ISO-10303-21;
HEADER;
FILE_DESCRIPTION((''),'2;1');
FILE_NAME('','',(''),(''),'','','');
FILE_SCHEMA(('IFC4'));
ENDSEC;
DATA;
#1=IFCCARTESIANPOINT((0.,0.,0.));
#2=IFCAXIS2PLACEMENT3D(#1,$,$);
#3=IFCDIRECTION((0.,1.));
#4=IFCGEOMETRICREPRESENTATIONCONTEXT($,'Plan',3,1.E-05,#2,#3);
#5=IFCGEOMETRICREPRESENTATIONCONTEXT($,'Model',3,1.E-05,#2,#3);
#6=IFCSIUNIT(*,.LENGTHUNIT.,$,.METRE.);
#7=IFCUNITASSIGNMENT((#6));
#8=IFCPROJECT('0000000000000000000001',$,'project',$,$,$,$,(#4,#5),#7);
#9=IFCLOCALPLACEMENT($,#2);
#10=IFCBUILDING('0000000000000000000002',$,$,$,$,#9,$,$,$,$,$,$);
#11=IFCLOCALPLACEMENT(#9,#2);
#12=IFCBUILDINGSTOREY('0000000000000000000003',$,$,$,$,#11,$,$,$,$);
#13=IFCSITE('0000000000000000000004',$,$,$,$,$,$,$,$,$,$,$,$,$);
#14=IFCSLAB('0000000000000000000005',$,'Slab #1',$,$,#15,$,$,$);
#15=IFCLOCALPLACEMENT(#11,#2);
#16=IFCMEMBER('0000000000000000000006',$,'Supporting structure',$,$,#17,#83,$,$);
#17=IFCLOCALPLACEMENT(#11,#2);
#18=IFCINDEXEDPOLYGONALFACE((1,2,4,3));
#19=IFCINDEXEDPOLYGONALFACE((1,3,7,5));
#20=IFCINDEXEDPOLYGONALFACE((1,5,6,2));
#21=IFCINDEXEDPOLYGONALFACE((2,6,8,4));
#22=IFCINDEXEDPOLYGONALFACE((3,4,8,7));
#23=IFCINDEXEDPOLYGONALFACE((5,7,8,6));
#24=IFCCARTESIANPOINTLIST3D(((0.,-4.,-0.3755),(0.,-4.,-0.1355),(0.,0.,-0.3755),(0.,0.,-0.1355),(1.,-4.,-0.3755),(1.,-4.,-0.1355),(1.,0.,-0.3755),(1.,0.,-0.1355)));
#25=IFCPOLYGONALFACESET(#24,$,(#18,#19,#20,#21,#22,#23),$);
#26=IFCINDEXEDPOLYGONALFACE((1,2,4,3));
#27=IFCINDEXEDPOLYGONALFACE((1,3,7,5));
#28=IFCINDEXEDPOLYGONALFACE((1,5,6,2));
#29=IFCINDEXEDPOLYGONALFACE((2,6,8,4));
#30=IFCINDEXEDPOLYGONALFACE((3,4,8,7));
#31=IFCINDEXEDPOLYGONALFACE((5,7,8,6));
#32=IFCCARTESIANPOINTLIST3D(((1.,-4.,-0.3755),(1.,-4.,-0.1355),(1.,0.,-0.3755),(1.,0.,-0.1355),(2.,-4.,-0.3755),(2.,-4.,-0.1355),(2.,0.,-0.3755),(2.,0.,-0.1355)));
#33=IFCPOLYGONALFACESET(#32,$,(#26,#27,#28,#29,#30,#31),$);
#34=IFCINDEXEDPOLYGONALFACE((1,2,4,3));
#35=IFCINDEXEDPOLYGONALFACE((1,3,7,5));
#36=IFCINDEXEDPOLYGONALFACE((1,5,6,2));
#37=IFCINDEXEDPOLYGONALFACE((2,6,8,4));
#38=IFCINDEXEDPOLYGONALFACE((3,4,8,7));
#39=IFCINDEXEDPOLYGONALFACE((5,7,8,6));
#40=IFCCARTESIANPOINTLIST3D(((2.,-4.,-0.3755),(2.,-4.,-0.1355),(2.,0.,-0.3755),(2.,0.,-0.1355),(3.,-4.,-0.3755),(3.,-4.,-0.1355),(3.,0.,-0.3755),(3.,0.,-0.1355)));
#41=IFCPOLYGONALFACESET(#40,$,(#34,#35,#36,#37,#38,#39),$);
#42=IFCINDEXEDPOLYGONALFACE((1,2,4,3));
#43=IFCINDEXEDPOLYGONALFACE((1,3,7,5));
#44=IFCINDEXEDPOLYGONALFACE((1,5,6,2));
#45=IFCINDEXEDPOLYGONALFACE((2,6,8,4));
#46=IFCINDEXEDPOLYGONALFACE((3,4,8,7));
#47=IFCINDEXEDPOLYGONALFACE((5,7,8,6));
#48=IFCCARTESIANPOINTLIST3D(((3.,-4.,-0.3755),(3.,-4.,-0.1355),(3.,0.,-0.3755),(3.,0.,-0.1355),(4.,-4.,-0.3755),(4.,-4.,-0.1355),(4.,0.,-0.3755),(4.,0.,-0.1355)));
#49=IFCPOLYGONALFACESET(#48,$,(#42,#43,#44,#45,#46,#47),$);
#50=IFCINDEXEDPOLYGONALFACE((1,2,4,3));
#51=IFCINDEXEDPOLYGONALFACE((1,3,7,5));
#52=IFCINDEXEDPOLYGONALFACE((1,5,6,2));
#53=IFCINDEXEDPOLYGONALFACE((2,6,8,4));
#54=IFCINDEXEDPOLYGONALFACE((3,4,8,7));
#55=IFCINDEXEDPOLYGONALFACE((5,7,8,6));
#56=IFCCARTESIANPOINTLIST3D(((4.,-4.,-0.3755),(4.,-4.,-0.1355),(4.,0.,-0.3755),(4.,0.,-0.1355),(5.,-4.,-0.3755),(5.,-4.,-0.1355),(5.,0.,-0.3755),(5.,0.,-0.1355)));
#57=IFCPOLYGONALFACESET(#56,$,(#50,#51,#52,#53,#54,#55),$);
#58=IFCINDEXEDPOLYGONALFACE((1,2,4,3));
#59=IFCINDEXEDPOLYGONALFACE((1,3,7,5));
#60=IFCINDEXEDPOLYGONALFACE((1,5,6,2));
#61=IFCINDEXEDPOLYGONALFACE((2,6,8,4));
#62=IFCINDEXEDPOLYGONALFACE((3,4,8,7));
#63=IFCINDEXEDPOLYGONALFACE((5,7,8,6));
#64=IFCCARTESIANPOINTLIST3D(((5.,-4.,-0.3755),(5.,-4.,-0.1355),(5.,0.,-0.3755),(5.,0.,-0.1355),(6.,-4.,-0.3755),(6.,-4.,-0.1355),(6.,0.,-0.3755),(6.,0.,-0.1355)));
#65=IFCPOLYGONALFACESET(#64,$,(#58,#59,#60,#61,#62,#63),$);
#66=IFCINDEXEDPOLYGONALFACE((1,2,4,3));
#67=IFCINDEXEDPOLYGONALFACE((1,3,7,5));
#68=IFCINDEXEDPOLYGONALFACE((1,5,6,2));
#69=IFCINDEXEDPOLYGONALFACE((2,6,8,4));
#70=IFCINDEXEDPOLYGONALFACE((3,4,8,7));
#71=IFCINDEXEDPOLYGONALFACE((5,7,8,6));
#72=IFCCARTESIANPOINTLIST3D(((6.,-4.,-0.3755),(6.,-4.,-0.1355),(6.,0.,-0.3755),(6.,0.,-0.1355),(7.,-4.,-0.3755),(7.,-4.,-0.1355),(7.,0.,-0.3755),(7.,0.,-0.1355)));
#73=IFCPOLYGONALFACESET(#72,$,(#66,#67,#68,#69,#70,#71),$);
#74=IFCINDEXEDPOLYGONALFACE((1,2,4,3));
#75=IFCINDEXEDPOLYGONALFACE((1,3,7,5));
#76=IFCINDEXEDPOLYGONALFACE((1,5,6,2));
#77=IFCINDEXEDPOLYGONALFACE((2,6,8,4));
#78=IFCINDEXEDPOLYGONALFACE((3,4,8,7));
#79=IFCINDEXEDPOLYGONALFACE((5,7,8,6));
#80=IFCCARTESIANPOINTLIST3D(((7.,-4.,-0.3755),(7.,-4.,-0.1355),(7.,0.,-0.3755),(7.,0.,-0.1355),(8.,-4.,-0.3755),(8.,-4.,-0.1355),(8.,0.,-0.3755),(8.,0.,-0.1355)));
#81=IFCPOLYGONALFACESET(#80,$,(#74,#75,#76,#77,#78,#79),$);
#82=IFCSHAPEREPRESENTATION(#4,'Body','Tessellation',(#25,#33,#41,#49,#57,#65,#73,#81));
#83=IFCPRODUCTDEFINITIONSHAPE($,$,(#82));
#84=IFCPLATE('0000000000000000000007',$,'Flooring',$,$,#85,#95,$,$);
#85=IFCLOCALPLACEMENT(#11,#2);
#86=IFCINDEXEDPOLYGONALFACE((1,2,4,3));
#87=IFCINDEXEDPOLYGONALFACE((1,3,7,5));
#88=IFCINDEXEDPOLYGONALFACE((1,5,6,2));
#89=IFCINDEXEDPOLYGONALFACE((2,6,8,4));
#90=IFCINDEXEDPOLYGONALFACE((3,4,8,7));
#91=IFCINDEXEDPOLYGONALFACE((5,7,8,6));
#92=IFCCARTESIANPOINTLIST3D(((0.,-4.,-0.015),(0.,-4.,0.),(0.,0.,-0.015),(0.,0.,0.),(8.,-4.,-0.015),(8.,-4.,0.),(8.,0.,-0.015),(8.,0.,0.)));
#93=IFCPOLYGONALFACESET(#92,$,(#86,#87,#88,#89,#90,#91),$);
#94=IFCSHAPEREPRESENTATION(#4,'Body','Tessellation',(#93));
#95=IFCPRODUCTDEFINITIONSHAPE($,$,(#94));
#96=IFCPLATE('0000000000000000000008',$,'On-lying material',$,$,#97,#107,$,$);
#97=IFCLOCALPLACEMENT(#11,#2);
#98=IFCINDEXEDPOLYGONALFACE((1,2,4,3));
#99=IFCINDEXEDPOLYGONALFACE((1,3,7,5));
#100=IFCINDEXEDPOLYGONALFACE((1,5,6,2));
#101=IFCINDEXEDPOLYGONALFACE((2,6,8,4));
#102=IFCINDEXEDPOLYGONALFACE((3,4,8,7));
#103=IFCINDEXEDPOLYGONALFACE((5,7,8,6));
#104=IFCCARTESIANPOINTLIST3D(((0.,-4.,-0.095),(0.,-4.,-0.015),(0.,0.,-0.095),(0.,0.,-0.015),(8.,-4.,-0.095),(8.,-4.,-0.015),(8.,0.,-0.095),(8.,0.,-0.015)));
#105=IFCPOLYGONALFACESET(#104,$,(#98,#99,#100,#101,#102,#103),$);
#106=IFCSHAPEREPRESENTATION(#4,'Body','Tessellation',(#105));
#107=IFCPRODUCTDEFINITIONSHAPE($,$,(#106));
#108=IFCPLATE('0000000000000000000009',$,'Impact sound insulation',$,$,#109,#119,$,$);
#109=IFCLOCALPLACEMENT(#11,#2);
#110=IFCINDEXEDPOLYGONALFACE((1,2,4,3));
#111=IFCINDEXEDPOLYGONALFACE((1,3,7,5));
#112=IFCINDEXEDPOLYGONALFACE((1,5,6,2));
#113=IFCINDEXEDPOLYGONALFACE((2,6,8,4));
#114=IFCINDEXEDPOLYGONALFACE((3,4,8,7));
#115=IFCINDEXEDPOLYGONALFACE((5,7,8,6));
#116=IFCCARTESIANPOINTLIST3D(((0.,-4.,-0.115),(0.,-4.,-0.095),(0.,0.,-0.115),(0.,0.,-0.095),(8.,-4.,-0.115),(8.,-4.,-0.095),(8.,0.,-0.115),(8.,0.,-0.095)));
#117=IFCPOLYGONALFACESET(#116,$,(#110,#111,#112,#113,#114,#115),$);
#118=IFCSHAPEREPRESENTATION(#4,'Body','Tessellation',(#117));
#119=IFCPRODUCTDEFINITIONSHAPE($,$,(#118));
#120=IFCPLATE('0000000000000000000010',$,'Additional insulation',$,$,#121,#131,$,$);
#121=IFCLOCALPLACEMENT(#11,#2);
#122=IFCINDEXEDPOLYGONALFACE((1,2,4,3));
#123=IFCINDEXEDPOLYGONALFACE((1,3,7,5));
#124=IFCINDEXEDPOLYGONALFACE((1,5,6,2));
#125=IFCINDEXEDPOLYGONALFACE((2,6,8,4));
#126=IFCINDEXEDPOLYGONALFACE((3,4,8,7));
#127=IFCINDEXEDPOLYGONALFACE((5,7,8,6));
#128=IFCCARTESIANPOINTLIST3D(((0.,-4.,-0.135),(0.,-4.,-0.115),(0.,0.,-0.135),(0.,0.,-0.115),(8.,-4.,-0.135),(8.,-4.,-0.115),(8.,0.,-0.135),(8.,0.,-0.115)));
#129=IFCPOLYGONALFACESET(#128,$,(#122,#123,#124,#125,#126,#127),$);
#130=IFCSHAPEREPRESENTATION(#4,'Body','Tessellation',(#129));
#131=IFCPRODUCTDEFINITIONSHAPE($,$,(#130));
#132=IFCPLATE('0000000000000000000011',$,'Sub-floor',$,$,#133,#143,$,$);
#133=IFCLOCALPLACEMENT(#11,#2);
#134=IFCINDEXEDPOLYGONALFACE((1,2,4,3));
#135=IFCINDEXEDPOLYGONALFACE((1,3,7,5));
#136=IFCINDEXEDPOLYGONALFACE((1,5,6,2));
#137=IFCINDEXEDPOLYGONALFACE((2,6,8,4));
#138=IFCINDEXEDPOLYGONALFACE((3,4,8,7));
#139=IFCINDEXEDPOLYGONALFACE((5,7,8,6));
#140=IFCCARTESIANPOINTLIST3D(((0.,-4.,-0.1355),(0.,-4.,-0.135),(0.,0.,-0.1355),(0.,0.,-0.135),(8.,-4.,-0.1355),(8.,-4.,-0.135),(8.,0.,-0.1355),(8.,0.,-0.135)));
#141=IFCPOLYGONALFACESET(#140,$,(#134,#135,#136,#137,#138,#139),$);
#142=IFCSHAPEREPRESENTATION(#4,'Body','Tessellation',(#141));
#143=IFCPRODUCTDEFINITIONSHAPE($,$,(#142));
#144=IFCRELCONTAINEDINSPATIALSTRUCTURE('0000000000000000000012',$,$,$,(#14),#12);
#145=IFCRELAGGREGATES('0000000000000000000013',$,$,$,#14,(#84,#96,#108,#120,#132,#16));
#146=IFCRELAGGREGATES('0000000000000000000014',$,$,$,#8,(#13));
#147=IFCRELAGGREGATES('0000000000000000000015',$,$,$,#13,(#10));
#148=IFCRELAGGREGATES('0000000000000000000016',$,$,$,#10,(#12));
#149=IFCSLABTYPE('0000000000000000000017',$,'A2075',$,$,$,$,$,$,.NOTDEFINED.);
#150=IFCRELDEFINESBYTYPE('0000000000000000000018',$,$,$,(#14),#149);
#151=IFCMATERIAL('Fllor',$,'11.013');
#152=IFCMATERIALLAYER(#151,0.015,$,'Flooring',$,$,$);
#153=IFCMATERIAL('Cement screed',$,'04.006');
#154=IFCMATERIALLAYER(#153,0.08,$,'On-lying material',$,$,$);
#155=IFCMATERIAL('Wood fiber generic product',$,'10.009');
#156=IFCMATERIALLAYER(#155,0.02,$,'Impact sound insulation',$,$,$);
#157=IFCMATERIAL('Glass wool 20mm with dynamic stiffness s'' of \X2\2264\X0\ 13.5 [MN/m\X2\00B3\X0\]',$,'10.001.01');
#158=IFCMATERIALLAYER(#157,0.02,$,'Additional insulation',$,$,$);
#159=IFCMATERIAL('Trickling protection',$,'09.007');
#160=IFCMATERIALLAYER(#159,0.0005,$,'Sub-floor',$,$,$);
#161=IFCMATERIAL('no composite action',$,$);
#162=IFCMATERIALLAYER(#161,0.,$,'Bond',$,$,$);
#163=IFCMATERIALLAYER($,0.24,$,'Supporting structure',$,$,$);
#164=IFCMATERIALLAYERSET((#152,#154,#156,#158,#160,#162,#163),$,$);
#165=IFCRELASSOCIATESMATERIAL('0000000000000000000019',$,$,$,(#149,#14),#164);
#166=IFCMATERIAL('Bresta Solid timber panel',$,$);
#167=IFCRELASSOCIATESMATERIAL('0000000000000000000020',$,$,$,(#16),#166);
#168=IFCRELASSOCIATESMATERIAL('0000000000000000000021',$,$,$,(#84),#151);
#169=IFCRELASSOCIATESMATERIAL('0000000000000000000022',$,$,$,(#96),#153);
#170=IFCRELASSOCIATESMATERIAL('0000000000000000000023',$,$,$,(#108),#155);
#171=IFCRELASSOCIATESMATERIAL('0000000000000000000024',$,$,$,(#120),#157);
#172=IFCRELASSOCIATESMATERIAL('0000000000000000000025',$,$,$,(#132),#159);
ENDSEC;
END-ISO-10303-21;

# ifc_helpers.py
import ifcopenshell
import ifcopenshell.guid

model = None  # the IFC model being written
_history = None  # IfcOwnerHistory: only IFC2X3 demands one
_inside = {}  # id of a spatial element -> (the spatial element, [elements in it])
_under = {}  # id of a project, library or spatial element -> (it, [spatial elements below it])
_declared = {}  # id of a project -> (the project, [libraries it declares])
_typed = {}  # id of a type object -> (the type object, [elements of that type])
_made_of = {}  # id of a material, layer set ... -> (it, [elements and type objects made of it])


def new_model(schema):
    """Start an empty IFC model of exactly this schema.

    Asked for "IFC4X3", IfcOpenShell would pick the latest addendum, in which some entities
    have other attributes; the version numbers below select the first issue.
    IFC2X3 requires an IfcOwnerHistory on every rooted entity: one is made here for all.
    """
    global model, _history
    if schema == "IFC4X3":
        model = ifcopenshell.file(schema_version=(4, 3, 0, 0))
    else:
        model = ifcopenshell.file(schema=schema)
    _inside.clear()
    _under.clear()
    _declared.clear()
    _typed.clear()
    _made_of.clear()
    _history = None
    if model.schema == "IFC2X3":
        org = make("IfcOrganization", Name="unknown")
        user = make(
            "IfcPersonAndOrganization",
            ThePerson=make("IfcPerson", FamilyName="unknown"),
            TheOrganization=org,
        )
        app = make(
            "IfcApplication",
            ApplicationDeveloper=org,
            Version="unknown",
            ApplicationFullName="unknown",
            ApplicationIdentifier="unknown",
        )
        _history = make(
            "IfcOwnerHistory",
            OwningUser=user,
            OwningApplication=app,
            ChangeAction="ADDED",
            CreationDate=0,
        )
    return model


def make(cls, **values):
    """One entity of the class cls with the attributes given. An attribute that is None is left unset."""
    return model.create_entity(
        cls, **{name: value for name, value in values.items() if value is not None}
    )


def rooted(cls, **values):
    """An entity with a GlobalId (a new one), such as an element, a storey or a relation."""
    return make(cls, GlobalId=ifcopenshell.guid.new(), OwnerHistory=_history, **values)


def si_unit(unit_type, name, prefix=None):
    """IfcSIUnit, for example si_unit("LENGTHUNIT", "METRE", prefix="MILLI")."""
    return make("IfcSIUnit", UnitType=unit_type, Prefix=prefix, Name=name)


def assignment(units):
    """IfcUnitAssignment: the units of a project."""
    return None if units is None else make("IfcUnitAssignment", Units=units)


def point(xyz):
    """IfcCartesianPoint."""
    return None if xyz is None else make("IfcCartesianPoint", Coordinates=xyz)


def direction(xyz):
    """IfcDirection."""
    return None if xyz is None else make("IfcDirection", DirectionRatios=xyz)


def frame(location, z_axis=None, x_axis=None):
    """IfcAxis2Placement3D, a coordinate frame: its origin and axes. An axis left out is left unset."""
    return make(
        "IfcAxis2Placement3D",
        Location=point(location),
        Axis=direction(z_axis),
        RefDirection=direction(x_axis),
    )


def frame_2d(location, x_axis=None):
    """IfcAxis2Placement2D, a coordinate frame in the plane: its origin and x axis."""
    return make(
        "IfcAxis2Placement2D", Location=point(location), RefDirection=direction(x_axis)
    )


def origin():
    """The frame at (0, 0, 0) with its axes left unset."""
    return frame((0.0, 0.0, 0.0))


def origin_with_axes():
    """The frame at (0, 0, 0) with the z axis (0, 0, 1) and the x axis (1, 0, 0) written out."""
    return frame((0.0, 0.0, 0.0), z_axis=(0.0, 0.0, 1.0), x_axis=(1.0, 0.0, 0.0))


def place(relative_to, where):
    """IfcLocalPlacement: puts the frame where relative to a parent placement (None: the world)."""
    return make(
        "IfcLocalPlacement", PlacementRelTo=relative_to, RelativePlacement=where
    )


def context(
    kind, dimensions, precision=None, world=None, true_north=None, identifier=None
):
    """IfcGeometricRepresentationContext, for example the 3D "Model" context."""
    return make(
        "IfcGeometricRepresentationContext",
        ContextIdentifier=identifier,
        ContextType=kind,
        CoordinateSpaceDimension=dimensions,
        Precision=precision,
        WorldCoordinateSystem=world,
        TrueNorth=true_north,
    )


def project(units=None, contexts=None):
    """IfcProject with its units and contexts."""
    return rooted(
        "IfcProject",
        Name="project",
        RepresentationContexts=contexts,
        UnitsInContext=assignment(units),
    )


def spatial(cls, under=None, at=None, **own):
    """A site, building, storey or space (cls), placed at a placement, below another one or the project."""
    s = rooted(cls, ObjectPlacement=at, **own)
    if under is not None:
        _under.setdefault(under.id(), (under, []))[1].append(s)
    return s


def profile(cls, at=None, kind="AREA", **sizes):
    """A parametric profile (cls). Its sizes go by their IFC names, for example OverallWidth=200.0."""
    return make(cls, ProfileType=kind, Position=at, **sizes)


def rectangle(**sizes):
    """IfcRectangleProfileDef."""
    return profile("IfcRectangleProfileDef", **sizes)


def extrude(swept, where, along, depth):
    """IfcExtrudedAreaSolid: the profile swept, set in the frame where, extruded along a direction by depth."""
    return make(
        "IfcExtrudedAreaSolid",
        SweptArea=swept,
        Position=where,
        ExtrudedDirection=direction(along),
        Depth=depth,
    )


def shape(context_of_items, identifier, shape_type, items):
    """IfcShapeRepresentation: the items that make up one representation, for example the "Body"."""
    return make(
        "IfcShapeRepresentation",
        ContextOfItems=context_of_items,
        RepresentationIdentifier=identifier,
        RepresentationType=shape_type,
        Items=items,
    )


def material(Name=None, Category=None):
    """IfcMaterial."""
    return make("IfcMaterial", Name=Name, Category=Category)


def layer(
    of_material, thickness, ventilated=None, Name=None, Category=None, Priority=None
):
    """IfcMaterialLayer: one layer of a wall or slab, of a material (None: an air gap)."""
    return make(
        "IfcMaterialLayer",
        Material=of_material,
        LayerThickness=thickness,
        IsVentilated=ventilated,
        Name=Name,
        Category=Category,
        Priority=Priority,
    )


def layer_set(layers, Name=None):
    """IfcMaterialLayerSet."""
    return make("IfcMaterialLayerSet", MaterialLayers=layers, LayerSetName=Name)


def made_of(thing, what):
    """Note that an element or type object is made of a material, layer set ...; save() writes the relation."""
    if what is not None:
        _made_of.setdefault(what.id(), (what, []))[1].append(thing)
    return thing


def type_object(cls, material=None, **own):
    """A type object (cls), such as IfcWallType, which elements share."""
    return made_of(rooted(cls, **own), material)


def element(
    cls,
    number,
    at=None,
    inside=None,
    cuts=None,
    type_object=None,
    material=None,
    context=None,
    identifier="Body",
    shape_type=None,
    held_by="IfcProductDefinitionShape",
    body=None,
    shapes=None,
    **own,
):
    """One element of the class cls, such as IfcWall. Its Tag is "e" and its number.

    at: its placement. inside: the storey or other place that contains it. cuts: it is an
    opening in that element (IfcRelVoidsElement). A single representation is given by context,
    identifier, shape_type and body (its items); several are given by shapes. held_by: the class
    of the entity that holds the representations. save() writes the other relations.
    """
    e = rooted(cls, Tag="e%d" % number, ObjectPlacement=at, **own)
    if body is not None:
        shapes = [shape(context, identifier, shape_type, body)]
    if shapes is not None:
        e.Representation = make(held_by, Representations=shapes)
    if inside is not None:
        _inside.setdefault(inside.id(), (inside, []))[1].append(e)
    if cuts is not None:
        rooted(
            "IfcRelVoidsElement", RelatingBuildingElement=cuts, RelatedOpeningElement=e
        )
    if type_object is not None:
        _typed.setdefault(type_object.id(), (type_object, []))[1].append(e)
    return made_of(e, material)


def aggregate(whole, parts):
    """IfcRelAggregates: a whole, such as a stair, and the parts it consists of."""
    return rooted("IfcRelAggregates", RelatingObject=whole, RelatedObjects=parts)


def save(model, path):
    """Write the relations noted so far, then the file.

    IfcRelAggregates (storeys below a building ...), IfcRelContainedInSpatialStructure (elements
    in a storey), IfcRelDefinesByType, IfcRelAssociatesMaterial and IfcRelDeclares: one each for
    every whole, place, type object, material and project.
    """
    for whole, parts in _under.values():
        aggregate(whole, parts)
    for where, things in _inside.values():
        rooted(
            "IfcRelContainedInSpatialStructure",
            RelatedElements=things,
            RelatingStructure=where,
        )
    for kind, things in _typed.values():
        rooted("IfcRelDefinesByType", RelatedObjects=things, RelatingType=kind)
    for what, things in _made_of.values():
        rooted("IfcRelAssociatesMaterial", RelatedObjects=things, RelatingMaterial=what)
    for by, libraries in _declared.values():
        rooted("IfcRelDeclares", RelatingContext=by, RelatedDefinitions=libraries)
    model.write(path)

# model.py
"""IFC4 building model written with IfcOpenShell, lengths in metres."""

from ifc_helpers import new_model, si_unit, direction, frame, frame_2d, origin, origin_with_axes, place, context, project, spatial, rectangle, extrude, material, layer, layer_set, type_object, element, aggregate, save


model = new_model("IFC4")

# Units and contexts
plan_context = context("Plan", 3, precision=1e-05, world=origin(), true_north=direction((0.0, 1.0)))
model_context = context("Model", 3, precision=1e-05, world=origin(), true_north=direction((0.0, 1.0)))
ifc_project = project(units=[si_unit("LENGTHUNIT", "METRE")], contexts=[plan_context, model_context])

# Site, building, storey
site = spatial("IfcSite", under=ifc_project)
building_placement = place(None, origin())
building = spatial("IfcBuilding", under=site, at=building_placement)
storey_placement = place(building_placement, origin())
storey = spatial("IfcBuildingStorey", under=building, at=storey_placement)

# Slab, member, plates
ifc_material_1 = material(Name="Fllor", Category="11.013")
ifc_layer_1 = layer(ifc_material_1, 0.015, Name="Flooring")
ifc_material_2 = material(Name="Cement screed", Category="04.006")
ifc_layer_2 = layer(ifc_material_2, 0.08, Name="On-lying material")
ifc_material_3 = material(Name="Wood fiber generic product", Category="10.009")
ifc_layer_3 = layer(ifc_material_3, 0.02, Name="Impact sound insulation")
ifc_material_4 = material(Name="Glass wool 20mm with dynamic stiffness s' of ≤ 13.5 [MN/m³]", Category="10.001.01")
ifc_layer_4 = layer(ifc_material_4, 0.02, Name="Additional insulation")
ifc_material_5 = material(Name="Trickling protection", Category="09.007")
ifc_layer_5 = layer(ifc_material_5, 0.0005, Name="Sub-floor")
ifc_material_6 = material(Name="no composite action")
ifc_layer_6 = layer(ifc_material_6, 0.0, Name="Bond")
ifc_layer_7 = layer(None, 0.24, Name="Supporting structure")
ifc_layer_set = layer_set([ifc_layer_1, ifc_layer_2, ifc_layer_3, ifc_layer_4, ifc_layer_5, ifc_layer_6, ifc_layer_7])
slab_type = type_object("IfcSlabType", Name="A2075", PredefinedType="NOTDEFINED", material=ifc_layer_set)
slab_placement = place(None, frame((0.0, 0.0, 0.0), z_axis=(0.0, 0.0, -1.0), x_axis=(1.0, 0.0, 0.0)))
slab = element("IfcSlab", 1, at=slab_placement, inside=storey, type_object=slab_type, material=ifc_layer_set, Name="Slab #1")
ifc_material_7 = material(Name="Bresta Solid timber panel")
member_placement = place(slab_placement, origin())
member = element("IfcMember", 2, at=member_placement, material=ifc_material_7, Name="Supporting structure", context=plan_context, shape_type="SweptSolid", body=[
    extrude(rectangle(XDim=1.0, YDim=0.24, at=frame_2d((0.5, 0.12), x_axis=(1.0, 0.0))), frame((0.0, 4.0, 0.1355), z_axis=(0.0, -1.0, 0.0), x_axis=(1.0, 0.0, 0.0)), (0.0, 0.0, 1.0), 4.0),
    extrude(rectangle(XDim=1.0, YDim=0.24, at=frame_2d((0.5, 0.12), x_axis=(1.0, 0.0))), frame((1.0, 4.0, 0.1355), z_axis=(0.0, -1.0, 0.0), x_axis=(1.0, 0.0, 0.0)), (0.0, 0.0, 1.0), 4.0),
    extrude(rectangle(XDim=1.0, YDim=0.24, at=frame_2d((0.5, 0.12), x_axis=(1.0, 0.0))), frame((2.0, 4.0, 0.1355), z_axis=(0.0, -1.0, 0.0), x_axis=(1.0, 0.0, 0.0)), (0.0, 0.0, 1.0), 4.0),
    extrude(rectangle(XDim=1.0, YDim=0.24, at=frame_2d((0.5, 0.12), x_axis=(1.0, 0.0))), frame((3.0, 4.0, 0.1355), z_axis=(0.0, -1.0, 0.0), x_axis=(1.0, 0.0, 0.0)), (0.0, 0.0, 1.0), 4.0),
    extrude(rectangle(XDim=1.0, YDim=0.24, at=frame_2d((0.5, 0.12), x_axis=(1.0, 0.0))), frame((4.0, 4.0, 0.1355), z_axis=(0.0, -1.0, 0.0), x_axis=(1.0, 0.0, 0.0)), (0.0, 0.0, 1.0), 4.0),
    extrude(rectangle(XDim=1.0, YDim=0.24, at=frame_2d((0.5, 0.12), x_axis=(1.0, 0.0))), frame((5.0, 4.0, 0.1355), z_axis=(0.0, -1.0, 0.0), x_axis=(1.0, 0.0, 0.0)), (0.0, 0.0, 1.0), 4.0),
    extrude(rectangle(XDim=1.0, YDim=0.24, at=frame_2d((0.5, 0.12), x_axis=(1.0, 0.0))), frame((6.0, 4.0, 0.1355), z_axis=(0.0, -1.0, 0.0), x_axis=(1.0, 0.0, 0.0)), (0.0, 0.0, 1.0), 4.0),
    extrude(rectangle(XDim=1.0, YDim=0.24, at=frame_2d((0.5, 0.12), x_axis=(1.0, 0.0))), frame((7.0, 4.0, 0.1355), z_axis=(0.0, -1.0, 0.0), x_axis=(1.0, 0.0, 0.0)), (0.0, 0.0, 1.0), 4.0),
])
plate_1_placement = place(slab_placement, origin())
plate_1 = element("IfcPlate", 3, at=plate_1_placement, material=ifc_material_1, Name="Flooring", context=plan_context, shape_type="SweptSolid", body=[
    extrude(rectangle(XDim=8.0, YDim=4.0, at=frame_2d((4.0, 2.0), x_axis=(1.0, 0.0))), origin_with_axes(), (0.0, 0.0, 1.0), 0.015),
])
plate_2_placement = place(slab_placement, origin())
plate_2 = element("IfcPlate", 4, at=plate_2_placement, material=ifc_material_2, Name="On-lying material", context=plan_context, shape_type="SweptSolid", body=[
    extrude(rectangle(XDim=8.0, YDim=4.0, at=frame_2d((4.0, 2.0), x_axis=(1.0, 0.0))), frame((0.0, 0.0, 0.015), z_axis=(0.0, 0.0, 1.0), x_axis=(1.0, 0.0, 0.0)), (0.0, 0.0, 1.0), 0.08),
])
plate_3_placement = place(slab_placement, origin())
plate_3 = element("IfcPlate", 5, at=plate_3_placement, material=ifc_material_3, Name="Impact sound insulation", context=plan_context, shape_type="SweptSolid", body=[
    extrude(rectangle(XDim=8.0, YDim=4.0, at=frame_2d((4.0, 2.0), x_axis=(1.0, 0.0))), frame((0.0, 0.0, 0.095), z_axis=(0.0, 0.0, 1.0), x_axis=(1.0, 0.0, 0.0)), (0.0, 0.0, 1.0), 0.02),
])
plate_4_placement = place(slab_placement, origin())
plate_4 = element("IfcPlate", 6, at=plate_4_placement, material=ifc_material_4, Name="Additional insulation", context=plan_context, shape_type="SweptSolid", body=[
    extrude(rectangle(XDim=8.0, YDim=4.0, at=frame_2d((4.0, 2.0), x_axis=(1.0, 0.0))), frame((0.0, 0.0, 0.115), z_axis=(0.0, 0.0, 1.0), x_axis=(1.0, 0.0, 0.0)), (0.0, 0.0, 1.0), 0.02),
])
plate_5_placement = place(slab_placement, origin())
plate_5 = element("IfcPlate", 7, at=plate_5_placement, material=ifc_material_5, Name="Sub-floor", context=plan_context, shape_type="SweptSolid", body=[
    extrude(rectangle(XDim=8.0, YDim=4.0, at=frame_2d((4.0, 2.0), x_axis=(1.0, 0.0))), frame((0.0, 0.0, 0.135), z_axis=(0.0, 0.0, 1.0), x_axis=(1.0, 0.0, 0.0)), (0.0, 0.0, 1.0), 0.0005),
])
aggregate(slab, [plate_1, plate_2, plate_3, plate_4, plate_5, member])

save(model, "model.ifc")
